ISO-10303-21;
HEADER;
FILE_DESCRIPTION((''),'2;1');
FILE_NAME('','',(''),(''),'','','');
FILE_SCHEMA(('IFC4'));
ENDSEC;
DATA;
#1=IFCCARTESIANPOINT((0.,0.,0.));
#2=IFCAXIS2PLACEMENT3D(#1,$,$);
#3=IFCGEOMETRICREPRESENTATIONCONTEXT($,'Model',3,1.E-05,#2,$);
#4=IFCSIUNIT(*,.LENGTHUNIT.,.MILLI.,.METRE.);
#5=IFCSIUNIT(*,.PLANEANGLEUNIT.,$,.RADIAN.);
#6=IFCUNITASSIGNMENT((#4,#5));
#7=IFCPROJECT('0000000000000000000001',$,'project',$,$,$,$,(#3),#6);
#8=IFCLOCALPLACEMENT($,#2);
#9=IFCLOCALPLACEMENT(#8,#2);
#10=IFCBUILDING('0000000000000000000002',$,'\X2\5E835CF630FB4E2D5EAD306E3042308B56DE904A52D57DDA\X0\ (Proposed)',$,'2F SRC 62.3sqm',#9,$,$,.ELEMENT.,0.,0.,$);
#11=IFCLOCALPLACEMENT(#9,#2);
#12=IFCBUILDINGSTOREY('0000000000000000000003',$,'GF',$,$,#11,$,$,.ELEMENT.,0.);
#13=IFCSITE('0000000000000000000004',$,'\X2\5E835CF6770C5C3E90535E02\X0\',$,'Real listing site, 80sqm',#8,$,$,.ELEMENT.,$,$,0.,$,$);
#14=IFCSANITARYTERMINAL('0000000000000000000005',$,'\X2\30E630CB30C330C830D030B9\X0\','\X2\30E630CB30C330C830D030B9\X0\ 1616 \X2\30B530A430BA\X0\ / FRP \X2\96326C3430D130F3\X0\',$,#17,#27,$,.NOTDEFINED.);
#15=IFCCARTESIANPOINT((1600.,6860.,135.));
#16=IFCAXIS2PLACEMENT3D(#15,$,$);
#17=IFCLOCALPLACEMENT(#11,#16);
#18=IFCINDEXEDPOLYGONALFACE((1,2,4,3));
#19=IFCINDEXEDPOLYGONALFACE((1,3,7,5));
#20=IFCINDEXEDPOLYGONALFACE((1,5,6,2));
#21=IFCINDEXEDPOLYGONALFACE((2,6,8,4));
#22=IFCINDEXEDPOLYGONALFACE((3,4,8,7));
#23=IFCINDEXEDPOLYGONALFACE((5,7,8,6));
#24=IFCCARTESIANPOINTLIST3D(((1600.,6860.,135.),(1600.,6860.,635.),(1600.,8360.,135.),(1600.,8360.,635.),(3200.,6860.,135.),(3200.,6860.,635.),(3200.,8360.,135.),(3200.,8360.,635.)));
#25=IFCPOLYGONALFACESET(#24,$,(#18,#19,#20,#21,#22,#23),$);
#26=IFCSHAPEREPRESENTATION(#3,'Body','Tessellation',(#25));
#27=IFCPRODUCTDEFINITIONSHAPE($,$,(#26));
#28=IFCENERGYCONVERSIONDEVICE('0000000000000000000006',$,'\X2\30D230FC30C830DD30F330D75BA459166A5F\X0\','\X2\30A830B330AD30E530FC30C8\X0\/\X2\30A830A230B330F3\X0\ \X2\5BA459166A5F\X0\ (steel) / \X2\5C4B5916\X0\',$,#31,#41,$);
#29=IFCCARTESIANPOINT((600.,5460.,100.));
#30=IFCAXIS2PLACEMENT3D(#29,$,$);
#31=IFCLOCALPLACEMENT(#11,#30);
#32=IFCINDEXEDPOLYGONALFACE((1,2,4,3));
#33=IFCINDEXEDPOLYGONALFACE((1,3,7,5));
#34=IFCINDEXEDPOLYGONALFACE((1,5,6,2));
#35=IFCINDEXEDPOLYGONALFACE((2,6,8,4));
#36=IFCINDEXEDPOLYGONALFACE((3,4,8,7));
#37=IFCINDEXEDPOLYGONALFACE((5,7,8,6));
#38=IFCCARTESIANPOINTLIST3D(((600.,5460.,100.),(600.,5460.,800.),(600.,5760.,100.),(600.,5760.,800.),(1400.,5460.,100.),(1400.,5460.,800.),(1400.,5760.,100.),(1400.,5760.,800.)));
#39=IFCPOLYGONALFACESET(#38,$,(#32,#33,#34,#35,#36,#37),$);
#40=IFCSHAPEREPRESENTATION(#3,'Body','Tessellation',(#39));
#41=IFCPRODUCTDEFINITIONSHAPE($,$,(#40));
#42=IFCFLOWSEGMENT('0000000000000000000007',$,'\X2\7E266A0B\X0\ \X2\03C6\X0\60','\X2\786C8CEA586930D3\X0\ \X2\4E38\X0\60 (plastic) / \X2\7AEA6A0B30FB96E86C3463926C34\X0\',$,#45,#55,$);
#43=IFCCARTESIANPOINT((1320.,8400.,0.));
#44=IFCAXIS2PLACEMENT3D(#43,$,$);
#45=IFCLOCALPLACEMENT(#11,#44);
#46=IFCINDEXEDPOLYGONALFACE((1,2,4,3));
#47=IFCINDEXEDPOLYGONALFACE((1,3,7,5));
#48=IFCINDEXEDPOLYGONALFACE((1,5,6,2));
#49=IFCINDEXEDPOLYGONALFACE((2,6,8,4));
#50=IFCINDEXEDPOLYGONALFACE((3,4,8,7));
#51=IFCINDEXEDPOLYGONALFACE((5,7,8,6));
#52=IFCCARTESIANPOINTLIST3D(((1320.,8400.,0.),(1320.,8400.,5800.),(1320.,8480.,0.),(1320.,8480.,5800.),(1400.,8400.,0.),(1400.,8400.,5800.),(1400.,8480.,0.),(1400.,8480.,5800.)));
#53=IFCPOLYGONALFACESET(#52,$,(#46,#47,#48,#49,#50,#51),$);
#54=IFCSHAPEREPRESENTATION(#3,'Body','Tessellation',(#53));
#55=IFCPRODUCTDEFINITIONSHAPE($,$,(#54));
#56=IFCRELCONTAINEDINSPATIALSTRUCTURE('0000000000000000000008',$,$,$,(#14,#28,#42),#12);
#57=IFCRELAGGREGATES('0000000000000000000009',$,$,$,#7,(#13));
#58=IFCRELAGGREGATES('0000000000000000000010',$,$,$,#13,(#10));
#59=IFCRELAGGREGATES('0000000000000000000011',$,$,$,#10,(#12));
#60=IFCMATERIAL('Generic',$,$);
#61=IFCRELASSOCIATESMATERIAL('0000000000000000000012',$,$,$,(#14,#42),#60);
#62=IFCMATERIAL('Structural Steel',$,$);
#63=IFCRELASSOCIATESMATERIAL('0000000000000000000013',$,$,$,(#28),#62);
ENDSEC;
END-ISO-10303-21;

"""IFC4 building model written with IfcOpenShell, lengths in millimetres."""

from ifc_helpers import new_model, si_unit, frame, frame_2d, origin, place, context, project, spatial, rectangle, extrude, material, element, save


model = new_model("IFC4")

# Units and contexts
model_context = context("Model", 3, precision=1e-05, world=origin())
ifc_project = project(units=[si_unit("LENGTHUNIT", "METRE", prefix="MILLI"), si_unit("PLANEANGLEUNIT", "RADIAN")], contexts=[model_context])

# Site, building, storey
site_placement = place(None, origin())
site = spatial("IfcSite", under=ifc_project, at=site_placement, Name="広島県尾道市", ObjectType="Real listing site, 80sqm", CompositionType="ELEMENT", RefElevation=0.0)
building_placement = place(site_placement, origin())
building = spatial("IfcBuilding", under=site, at=building_placement, Name="広島・中庭のある回遊動線 (Proposed)", ObjectType="2F SRC 62.3sqm", CompositionType="ELEMENT", ElevationOfRefHeight=0.0, ElevationOfTerrain=0.0)
storey_placement = place(building_placement, origin())
storey = spatial("IfcBuildingStorey", under=building, at=storey_placement, Name="GF", CompositionType="ELEMENT", Elevation=0.0)

# Shared definitions
ifc_material_1 = material(Name="Generic")

# Sanitary terminal
sanitary_terminal_placement = place(storey_placement, frame((1600.0, 6860.0, 135.0)))
element("IfcSanitaryTerminal", 1, at=sanitary_terminal_placement, inside=storey, material=ifc_material_1, Name="ユニットバス", Description="ユニットバス 1616 サイズ / FRP 防水パン", PredefinedType="NOTDEFINED", context=model_context, shape_type="SweptSolid", body=[
    extrude(rectangle(XDim=1600.0, YDim=1500.0, at=frame_2d((800.0, 750.0))), frame((1600.0, 6860.0, 135.0)), (0.0, 0.0, 1.0), 500.0),
])

# Energy conversion device
ifc_material_2 = material(Name="Structural Steel")
energy_conversion_device_placement = place(storey_placement, frame((600.0, 5460.0, 100.0)))
element("IfcEnergyConversionDevice", 2, at=energy_conversion_device_placement, inside=storey, material=ifc_material_2, Name="ヒートポンプ室外機", Description="エコキュート/エアコン 室外機 (steel) / 屋外", context=model_context, shape_type="SweptSolid", body=[
    extrude(rectangle(XDim=800.0, YDim=300.0, at=frame_2d((400.0, 150.0))), frame((600.0, 5460.0, 100.0)), (0.0, 0.0, 1.0), 700.0),
])

# Flow segment
flow_segment_placement = place(storey_placement, frame((1320.0, 8400.0, 0.0)))
element("IfcFlowSegment", 3, at=flow_segment_placement, inside=storey, material=ifc_material_1, Name="縦樋 φ60", Description="硬質塩ビ 丸60 (plastic) / 竪樋・雨水排水", context=model_context, shape_type="SweptSolid", body=[
    extrude(rectangle(XDim=80.0, YDim=80.0, at=frame_2d((40.0, 40.0))), frame((1320.0, 8400.0, 0.0)), (0.0, 0.0, 1.0), 5800.0),
])

save(model, "model.ifc")
